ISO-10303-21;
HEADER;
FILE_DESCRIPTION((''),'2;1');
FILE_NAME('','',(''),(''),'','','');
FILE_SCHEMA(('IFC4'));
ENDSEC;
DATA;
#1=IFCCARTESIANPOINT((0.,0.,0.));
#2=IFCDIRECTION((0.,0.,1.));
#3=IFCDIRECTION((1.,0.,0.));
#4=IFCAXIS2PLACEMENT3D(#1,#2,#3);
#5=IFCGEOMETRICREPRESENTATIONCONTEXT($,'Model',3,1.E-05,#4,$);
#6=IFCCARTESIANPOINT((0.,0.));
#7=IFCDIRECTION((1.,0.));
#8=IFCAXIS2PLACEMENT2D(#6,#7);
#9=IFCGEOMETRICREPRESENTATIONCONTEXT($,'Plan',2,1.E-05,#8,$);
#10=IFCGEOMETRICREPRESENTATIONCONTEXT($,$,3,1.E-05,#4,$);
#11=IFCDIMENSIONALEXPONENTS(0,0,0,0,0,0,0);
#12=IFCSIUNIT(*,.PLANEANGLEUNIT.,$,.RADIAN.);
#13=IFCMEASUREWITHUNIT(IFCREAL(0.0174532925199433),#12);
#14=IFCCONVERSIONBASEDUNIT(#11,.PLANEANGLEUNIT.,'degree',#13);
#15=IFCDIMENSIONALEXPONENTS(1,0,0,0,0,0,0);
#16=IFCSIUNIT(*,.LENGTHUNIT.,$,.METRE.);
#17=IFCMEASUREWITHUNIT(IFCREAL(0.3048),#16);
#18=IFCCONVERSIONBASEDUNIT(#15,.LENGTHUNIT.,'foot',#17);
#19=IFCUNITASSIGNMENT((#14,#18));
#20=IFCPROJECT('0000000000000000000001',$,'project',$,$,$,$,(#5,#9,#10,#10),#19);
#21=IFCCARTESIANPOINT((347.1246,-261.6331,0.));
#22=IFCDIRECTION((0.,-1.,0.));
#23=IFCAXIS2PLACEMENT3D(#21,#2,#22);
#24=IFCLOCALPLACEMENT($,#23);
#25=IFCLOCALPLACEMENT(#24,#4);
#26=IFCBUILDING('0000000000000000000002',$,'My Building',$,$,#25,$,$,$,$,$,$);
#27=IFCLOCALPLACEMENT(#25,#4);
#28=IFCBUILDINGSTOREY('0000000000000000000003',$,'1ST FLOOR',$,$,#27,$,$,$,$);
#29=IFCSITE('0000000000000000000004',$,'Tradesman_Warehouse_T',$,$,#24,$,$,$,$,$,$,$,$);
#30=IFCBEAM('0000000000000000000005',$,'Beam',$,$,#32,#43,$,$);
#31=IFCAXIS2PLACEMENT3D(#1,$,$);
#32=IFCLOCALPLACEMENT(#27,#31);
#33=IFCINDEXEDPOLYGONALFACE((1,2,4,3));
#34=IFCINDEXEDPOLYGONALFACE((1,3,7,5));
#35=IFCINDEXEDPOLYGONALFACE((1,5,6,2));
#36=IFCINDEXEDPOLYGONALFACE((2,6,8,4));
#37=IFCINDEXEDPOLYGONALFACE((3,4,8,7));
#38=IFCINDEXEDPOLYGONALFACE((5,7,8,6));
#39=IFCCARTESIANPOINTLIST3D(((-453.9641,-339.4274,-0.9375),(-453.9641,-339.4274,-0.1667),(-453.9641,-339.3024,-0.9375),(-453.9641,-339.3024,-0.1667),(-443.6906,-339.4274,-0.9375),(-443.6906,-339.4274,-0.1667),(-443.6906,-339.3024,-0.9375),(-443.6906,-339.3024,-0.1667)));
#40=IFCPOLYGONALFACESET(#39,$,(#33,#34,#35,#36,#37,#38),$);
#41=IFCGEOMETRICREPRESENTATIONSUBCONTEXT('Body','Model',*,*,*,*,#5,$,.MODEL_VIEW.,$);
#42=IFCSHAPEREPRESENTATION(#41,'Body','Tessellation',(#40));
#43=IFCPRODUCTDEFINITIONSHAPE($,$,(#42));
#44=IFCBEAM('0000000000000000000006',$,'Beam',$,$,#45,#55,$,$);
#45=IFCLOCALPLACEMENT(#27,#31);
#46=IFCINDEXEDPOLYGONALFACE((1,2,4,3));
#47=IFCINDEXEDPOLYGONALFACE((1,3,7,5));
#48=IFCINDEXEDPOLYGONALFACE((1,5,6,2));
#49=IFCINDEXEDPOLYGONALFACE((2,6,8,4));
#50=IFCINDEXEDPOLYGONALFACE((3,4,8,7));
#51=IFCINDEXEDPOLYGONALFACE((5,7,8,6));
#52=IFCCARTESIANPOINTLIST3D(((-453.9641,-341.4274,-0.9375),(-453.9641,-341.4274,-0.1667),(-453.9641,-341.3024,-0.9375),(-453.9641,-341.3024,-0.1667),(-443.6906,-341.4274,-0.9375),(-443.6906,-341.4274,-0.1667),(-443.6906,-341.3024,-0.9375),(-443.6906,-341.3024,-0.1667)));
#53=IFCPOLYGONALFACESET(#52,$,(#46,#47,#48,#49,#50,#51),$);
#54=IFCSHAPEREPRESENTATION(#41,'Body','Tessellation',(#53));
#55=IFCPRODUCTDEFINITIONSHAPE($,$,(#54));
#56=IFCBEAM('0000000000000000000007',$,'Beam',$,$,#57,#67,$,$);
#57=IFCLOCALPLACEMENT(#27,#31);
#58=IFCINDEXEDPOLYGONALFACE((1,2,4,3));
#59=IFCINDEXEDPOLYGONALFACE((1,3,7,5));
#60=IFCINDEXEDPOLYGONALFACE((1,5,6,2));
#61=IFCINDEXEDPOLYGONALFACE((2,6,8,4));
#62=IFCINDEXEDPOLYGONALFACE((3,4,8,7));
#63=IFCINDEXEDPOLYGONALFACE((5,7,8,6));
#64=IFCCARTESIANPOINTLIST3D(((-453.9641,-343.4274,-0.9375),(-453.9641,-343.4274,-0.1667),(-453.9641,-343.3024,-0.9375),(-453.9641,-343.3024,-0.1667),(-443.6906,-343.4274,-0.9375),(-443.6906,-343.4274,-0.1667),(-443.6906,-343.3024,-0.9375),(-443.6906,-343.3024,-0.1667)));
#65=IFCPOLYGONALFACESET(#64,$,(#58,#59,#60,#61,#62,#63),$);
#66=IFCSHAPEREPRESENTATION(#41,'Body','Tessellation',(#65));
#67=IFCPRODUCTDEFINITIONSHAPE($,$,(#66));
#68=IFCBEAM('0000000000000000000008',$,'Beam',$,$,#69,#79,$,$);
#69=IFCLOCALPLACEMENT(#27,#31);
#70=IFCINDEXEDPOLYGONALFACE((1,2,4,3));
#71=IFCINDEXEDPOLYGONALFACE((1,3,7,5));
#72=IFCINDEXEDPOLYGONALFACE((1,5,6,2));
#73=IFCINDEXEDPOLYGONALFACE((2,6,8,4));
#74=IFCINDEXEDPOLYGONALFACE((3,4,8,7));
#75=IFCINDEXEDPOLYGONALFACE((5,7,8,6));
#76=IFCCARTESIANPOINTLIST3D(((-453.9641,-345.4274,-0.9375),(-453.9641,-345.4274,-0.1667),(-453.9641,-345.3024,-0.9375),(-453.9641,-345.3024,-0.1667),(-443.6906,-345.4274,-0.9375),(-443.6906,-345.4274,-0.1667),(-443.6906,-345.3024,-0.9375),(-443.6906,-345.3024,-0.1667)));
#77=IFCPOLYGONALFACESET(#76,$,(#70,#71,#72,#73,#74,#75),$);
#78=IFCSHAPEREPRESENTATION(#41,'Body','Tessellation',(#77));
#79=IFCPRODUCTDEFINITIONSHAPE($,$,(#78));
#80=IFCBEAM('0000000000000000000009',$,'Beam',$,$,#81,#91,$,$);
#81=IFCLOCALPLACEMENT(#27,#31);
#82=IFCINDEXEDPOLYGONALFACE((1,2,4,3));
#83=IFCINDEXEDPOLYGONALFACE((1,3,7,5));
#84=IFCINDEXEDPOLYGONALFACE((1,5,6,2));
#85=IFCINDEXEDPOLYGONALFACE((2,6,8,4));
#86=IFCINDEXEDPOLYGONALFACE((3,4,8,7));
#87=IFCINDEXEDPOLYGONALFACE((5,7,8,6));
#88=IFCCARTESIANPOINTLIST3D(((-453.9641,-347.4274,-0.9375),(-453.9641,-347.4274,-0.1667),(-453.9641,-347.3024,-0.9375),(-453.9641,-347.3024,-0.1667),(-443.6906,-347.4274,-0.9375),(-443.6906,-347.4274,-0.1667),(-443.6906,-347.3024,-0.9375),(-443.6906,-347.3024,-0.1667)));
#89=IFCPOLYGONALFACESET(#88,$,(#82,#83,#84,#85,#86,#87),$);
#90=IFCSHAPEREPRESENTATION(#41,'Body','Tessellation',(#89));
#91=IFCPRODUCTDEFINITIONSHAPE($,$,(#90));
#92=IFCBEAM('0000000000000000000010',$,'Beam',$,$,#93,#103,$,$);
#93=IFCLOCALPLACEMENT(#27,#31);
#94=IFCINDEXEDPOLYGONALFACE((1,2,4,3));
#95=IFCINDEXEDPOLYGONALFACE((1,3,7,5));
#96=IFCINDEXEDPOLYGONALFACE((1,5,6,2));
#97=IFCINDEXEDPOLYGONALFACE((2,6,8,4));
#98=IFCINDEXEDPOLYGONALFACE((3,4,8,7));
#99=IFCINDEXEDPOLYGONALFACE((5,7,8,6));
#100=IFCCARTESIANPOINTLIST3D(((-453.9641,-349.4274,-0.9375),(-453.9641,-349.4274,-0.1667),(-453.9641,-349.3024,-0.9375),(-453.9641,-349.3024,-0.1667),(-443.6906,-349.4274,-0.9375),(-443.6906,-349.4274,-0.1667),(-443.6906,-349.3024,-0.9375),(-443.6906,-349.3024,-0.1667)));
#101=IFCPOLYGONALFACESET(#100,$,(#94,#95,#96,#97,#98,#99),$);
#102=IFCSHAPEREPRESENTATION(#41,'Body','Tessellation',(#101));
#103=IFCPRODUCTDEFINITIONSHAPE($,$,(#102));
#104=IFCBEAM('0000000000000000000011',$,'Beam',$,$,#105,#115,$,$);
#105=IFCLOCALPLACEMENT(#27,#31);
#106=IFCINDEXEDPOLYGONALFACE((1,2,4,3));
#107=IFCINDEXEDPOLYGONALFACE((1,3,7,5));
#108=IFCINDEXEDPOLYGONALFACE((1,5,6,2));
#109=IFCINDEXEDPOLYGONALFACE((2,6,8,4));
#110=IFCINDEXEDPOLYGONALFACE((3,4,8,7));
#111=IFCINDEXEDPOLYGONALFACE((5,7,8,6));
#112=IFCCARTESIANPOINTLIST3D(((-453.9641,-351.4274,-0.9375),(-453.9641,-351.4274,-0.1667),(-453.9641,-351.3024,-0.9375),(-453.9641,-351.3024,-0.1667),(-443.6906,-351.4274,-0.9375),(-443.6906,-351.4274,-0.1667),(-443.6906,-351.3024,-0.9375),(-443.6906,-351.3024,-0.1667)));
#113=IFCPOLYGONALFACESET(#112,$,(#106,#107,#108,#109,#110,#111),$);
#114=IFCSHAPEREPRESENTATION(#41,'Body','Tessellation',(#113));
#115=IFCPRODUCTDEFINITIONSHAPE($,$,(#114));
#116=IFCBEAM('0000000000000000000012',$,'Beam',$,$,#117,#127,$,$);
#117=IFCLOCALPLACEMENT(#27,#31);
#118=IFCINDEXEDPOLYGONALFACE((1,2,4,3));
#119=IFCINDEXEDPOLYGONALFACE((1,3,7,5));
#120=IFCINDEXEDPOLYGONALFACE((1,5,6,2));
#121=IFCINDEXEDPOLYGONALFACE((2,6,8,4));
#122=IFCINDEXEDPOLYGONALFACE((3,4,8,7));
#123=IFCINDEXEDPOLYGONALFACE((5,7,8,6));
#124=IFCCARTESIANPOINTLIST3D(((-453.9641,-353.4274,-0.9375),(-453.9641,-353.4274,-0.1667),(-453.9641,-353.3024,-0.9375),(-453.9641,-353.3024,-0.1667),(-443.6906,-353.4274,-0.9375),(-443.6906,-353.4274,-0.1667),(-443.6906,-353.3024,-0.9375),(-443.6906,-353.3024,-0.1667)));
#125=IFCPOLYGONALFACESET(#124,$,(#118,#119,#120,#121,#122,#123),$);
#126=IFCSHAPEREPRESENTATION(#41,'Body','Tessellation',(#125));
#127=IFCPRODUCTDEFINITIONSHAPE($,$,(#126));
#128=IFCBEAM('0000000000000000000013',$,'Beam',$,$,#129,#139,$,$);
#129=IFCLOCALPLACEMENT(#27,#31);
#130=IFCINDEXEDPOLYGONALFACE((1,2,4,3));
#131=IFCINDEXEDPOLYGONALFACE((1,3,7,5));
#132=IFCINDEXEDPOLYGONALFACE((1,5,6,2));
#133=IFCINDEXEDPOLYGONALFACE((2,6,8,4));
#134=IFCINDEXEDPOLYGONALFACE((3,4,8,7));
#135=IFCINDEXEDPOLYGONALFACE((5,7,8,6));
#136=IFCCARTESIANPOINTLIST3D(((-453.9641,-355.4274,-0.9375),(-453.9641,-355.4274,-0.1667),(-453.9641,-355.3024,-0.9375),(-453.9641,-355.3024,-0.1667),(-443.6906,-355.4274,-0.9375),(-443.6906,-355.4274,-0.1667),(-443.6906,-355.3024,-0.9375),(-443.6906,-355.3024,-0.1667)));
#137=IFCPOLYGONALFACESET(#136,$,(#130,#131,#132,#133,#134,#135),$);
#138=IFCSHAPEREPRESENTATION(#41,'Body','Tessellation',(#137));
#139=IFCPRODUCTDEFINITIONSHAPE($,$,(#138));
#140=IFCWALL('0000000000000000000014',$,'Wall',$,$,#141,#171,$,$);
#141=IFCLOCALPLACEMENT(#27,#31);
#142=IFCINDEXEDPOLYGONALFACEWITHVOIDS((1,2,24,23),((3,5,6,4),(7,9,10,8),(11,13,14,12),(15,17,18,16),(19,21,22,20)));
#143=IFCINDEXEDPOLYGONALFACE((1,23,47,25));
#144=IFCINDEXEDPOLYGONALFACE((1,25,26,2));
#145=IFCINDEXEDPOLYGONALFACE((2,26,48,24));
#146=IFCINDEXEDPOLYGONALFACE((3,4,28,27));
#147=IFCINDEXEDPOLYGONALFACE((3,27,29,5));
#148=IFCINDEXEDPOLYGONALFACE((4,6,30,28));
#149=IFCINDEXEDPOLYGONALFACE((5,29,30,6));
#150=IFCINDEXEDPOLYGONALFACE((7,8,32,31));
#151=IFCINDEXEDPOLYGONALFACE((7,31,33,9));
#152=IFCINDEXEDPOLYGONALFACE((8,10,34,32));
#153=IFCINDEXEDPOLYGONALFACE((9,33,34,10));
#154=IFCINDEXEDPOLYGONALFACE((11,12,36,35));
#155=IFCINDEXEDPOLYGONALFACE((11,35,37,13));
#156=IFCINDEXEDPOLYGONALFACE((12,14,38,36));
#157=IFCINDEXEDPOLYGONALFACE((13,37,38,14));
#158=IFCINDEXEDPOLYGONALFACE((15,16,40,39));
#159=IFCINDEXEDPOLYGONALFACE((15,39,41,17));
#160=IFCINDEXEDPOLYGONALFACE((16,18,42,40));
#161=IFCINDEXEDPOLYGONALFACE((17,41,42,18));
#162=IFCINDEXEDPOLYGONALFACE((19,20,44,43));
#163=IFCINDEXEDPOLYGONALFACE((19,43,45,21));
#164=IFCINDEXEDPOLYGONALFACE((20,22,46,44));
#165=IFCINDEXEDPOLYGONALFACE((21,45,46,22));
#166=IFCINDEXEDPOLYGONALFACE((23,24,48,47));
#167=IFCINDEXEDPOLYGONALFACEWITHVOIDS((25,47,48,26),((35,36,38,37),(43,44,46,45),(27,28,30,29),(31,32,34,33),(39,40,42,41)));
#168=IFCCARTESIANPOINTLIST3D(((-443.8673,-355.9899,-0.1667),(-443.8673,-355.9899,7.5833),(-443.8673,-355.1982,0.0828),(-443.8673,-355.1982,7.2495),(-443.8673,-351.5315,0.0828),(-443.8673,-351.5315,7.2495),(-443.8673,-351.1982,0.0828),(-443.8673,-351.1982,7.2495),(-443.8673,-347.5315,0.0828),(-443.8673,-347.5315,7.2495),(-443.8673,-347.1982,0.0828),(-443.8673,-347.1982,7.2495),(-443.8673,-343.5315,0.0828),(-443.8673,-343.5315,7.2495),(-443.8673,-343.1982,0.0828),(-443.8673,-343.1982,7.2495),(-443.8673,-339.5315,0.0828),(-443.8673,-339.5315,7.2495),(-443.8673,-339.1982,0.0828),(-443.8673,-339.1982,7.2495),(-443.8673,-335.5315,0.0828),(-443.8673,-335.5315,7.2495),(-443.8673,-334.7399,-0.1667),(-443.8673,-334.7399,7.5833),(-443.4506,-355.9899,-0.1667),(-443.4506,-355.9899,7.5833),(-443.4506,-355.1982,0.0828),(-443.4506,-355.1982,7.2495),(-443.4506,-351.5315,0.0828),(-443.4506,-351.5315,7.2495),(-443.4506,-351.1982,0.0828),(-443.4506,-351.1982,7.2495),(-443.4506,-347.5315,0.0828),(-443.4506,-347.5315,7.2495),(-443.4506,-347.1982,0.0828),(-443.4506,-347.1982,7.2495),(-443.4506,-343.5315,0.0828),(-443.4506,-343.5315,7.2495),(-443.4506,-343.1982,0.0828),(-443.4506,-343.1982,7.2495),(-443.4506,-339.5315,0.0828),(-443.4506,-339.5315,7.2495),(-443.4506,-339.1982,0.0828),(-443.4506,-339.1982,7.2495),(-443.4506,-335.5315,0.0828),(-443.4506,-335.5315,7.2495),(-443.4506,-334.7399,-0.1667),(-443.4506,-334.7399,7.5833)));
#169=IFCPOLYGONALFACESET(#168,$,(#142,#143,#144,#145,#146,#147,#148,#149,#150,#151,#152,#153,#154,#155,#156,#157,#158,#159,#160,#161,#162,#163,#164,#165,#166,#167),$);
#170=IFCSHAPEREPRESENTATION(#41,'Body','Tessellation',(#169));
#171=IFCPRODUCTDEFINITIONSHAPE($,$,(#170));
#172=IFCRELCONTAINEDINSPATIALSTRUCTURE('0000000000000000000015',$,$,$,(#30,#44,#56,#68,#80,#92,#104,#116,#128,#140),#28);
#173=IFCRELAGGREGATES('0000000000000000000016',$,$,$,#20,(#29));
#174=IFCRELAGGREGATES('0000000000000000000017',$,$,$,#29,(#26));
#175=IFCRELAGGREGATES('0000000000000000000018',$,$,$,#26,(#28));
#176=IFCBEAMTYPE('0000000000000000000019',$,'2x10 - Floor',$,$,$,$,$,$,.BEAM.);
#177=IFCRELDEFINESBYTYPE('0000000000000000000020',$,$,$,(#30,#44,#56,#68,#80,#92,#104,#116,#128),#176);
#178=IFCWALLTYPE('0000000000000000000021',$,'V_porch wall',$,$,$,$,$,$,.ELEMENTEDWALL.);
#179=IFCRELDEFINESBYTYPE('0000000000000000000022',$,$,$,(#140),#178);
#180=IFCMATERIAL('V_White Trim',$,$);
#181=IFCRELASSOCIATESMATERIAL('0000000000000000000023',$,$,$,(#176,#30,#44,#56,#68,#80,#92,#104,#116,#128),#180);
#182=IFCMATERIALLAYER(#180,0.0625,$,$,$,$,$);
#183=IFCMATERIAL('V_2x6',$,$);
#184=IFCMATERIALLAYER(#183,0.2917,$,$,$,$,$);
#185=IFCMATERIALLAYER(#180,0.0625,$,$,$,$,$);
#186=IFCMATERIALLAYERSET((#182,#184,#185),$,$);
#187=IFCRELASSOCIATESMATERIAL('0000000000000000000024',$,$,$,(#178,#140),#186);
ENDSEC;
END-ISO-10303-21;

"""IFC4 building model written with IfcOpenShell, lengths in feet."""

from ifc_helpers import new_model, entity, si_unit, converted_unit, frame, origin_with_axes, origin_2d_with_axis, place, context, subcontext, project, spatial, line, indexed_curve, rectangle, outline, extrude, source, transform, mapped, material, layer, layer_set, layer_usage, material_profile, profile_set, profile_usage, type_object, element, save


model = new_model("IFC4")

# Units and contexts
model_context = context("Model", 3, precision=1e-05, world=origin_with_axes())
plan_context = context("Plan", 2, precision=1e-05, world=origin_2d_with_axis())
context_of_model = context(None, 3, precision=1e-05, world=origin_with_axes())
body_context = subcontext(model_context, "Body", "Model", "MODEL_VIEW")
ifc_project = project(units=[converted_unit("PLANEANGLEUNIT", "degree", entity("IfcReal", 0.0174532925199433), si_unit("PLANEANGLEUNIT", "RADIAN"), dimensions=[0, 0, 0, 0, 0, 0, 0]), converted_unit("LENGTHUNIT", "foot", entity("IfcReal", 0.3048), si_unit("LENGTHUNIT", "METRE"), dimensions=[1, 0, 0, 0, 0, 0, 0])], contexts=[model_context, plan_context, context_of_model, context_of_model])

# Site, building, storey
site_placement = place(None, frame((347.1246, -261.6331, 0.0), z_axis=(0.0, 0.0, 1.0), x_axis=(0.0, -1.0, 0.0)))
site = spatial("IfcSite", under=ifc_project, at=site_placement, Name="Tradesman_Warehouse_T")
building_placement = place(site_placement, frame((0.0, 0.0, 0.0), z_axis=(0.0, 0.0, 1.0), x_axis=(1.0, 0.0, 0.0)))
building = spatial("IfcBuilding", under=site, at=building_placement, Name="My Building")
storey_placement = place(building_placement, frame((0.0, 0.0, 0.0), z_axis=(0.0, 0.0, 1.0), x_axis=(1.0, 0.0, 0.0)))
storey = spatial("IfcBuildingStorey", under=building, at=storey_placement, Name="1ST FLOOR")

# Beams
ifc_material_1 = material(Name="V_White Trim")
ifc_material_profile_1 = material_profile(ifc_material_1, rectangle(XDim=0.125, YDim=0.7708))
ifc_profile_set_1 = profile_set([ifc_material_profile_1])
ifc_profile_usage_1 = profile_usage(ifc_profile_set_1, cardinal=5)
beam_type_1 = type_object("IfcBeamType", Name="2x10 - Floor", PredefinedType="BEAM", material=ifc_profile_set_1)
beam_1_placement = place(storey_placement, frame((-453.9641, -339.3649, -0.5521), z_axis=(1.0, 0.0, 0.0), x_axis=(0.0, 1.0, 0.0)))
element("IfcBeam", 1, at=beam_1_placement, inside=storey, type_object=beam_type_1, material=ifc_profile_usage_1, Name="Beam", context=body_context, shape_type="SweptSolid", body=[
    extrude(rectangle(XDim=0.125, YDim=0.7708), origin_with_axes(), (0.0, 0.0, 1.0), 10.2735),
])
ifc_profile_usage_2 = profile_usage(ifc_profile_set_1, cardinal=5)
beam_2_placement = place(storey_placement, frame((-453.9641, -341.3649, -0.5521), z_axis=(1.0, 0.0, 0.0), x_axis=(0.0, 1.0, 0.0)))
element("IfcBeam", 2, at=beam_2_placement, inside=storey, type_object=beam_type_1, material=ifc_profile_usage_2, Name="Beam", context=body_context, shape_type="SweptSolid", body=[
    extrude(rectangle(XDim=0.125, YDim=0.7708), origin_with_axes(), (0.0, 0.0, 1.0), 10.2735),
])
ifc_profile_usage_3 = profile_usage(ifc_profile_set_1, cardinal=5)
beam_3_placement = place(storey_placement, frame((-453.9641, -343.3649, -0.5521), z_axis=(1.0, 0.0, 0.0), x_axis=(0.0, 1.0, 0.0)))
element("IfcBeam", 3, at=beam_3_placement, inside=storey, type_object=beam_type_1, material=ifc_profile_usage_3, Name="Beam", context=body_context, shape_type="SweptSolid", body=[
    extrude(rectangle(XDim=0.125, YDim=0.7708), origin_with_axes(), (0.0, 0.0, 1.0), 10.2735),
])
ifc_profile_usage_4 = profile_usage(ifc_profile_set_1, cardinal=5)
beam_4_placement = place(storey_placement, frame((-453.9641, -345.3649, -0.5521), z_axis=(1.0, 0.0, 0.0), x_axis=(0.0, 1.0, 0.0)))
element("IfcBeam", 4, at=beam_4_placement, inside=storey, type_object=beam_type_1, material=ifc_profile_usage_4, Name="Beam", context=body_context, shape_type="SweptSolid", body=[
    extrude(rectangle(XDim=0.125, YDim=0.7708), origin_with_axes(), (0.0, 0.0, 1.0), 10.2735),
])
ifc_profile_usage_5 = profile_usage(ifc_profile_set_1, cardinal=5)
beam_5_placement = place(storey_placement, frame((-453.9641, -347.3649, -0.5521), z_axis=(1.0, 0.0, 0.0), x_axis=(0.0, 1.0, 0.0)))
element("IfcBeam", 5, at=beam_5_placement, inside=storey, type_object=beam_type_1, material=ifc_profile_usage_5, Name="Beam", context=body_context, shape_type="SweptSolid", body=[
    extrude(rectangle(XDim=0.125, YDim=0.7708), origin_with_axes(), (0.0, 0.0, 1.0), 10.2735),
])
ifc_profile_usage_6 = profile_usage(ifc_profile_set_1, cardinal=5)
beam_6_placement = place(storey_placement, frame((-453.9641, -349.3649, -0.5521), z_axis=(1.0, 0.0, 0.0), x_axis=(0.0, 1.0, 0.0)))
element("IfcBeam", 6, at=beam_6_placement, inside=storey, type_object=beam_type_1, material=ifc_profile_usage_6, Name="Beam", context=body_context, shape_type="SweptSolid", body=[
    extrude(rectangle(XDim=0.125, YDim=0.7708), origin_with_axes(), (0.0, 0.0, 1.0), 10.2735),
])
ifc_profile_usage_7 = profile_usage(ifc_profile_set_1, cardinal=5)
beam_7_placement = place(storey_placement, frame((-453.9641, -351.3649, -0.5521), z_axis=(1.0, 0.0, 0.0), x_axis=(0.0, 1.0, 0.0)))
element("IfcBeam", 7, at=beam_7_placement, inside=storey, type_object=beam_type_1, material=ifc_profile_usage_7, Name="Beam", context=body_context, shape_type="SweptSolid", body=[
    extrude(rectangle(XDim=0.125, YDim=0.7708), origin_with_axes(), (0.0, 0.0, 1.0), 10.2735),
])
ifc_profile_usage_8 = profile_usage(ifc_profile_set_1, cardinal=5)
beam_8_placement = place(storey_placement, frame((-453.9641, -353.3649, -0.5521), z_axis=(1.0, 0.0, 0.0), x_axis=(0.0, 1.0, 0.0)))
element("IfcBeam", 8, at=beam_8_placement, inside=storey, type_object=beam_type_1, material=ifc_profile_usage_8, Name="Beam", context=body_context, shape_type="SweptSolid", body=[
    extrude(rectangle(XDim=0.125, YDim=0.7708), origin_with_axes(), (0.0, 0.0, 1.0), 10.2735),
])
ifc_profile_usage_9 = profile_usage(ifc_profile_set_1, cardinal=5)
beam_9_placement = place(storey_placement, frame((-453.9641, -355.3649, -0.5521), z_axis=(1.0, 0.0, 0.0), x_axis=(0.0, 1.0, 0.0)))
element("IfcBeam", 9, at=beam_9_placement, inside=storey, type_object=beam_type_1, material=ifc_profile_usage_9, Name="Beam", context=body_context, shape_type="SweptSolid", body=[
    extrude(rectangle(XDim=0.125, YDim=0.7708), origin_with_axes(), (0.0, 0.0, 1.0), 10.2735),
])

# Wall, openings
ifc_layer_1 = layer(ifc_material_1, 0.0625)
ifc_material_2 = material(Name="V_2x6")
ifc_layer_2 = layer(ifc_material_2, 0.2917)
ifc_layer_3 = layer(ifc_material_1, 0.0625)
ifc_layer_set_1 = layer_set([ifc_layer_1, ifc_layer_2, ifc_layer_3])
ifc_layer_usage_1 = layer_usage(ifc_layer_set_1, "AXIS2", "POSITIVE", 0.0)
wall_type_1 = type_object("IfcWallType", Name="V_porch wall", PredefinedType="ELEMENTEDWALL", material=ifc_layer_set_1)
wall_1_placement = place(storey_placement, frame((-443.4506, -355.9899, -0.1667), z_axis=(0.0, 0.0, 1.0), x_axis=(0.0, 1.0, 0.0)))
wall_1 = element("IfcWall", 10, at=wall_1_placement, inside=storey, type_object=wall_type_1, material=ifc_layer_usage_1, Name="Wall", context=body_context, shape_type="SweptSolid", body=[
    extrude(outline(indexed_curve([(0.0, 0.0), (0.0, 0.4167), (21.25, 0.4167), (21.25, 0.0), (0.0, 0.0)], self_intersect=False)), origin_with_axes(), (0.0, 0.0, 1.0), 7.75),
])
shared_shape = source(origin_with_axes(), body_context, "Body", "SweptSolid", [
    extrude(outline(indexed_curve([(0.0, 0.0), (3.6667, 0.0), (3.6667, 7.1667), (0.0, 7.1667)], segments=[line(1, 2, 3, 4, 1)])), frame((0.0, -1.9685, 0.0), z_axis=(0.0, -1.0, 0.0), x_axis=(1.0, 0.0, 0.0)), (0.0, 0.0, -1.0), 3.937),
])
opening_1_placement = place(wall_1_placement, frame((16.7917, 0.0, 0.2495), z_axis=(0.0, 0.0, 1.0), x_axis=(1.0, 0.0, 0.0)))
element("IfcOpeningElement", 11, at=opening_1_placement, cuts=wall_1, PredefinedType="OPENING", context=body_context, shape_type="MappedRepresentation", body=[
    mapped(shared_shape, transform((0.0, 0.0, 0.0), x_axis=(1.0, 0.0, 0.0), y_axis=(0.0, 1.0, 0.0), z_axis=(0.0, 0.0, 1.0), scale=1.0)),
])
opening_2_placement = place(wall_1_placement, frame((12.7917, 0.0, 0.2495), z_axis=(0.0, 0.0, 1.0), x_axis=(1.0, 0.0, 0.0)))
element("IfcOpeningElement", 12, at=opening_2_placement, cuts=wall_1, PredefinedType="OPENING", context=body_context, shape_type="MappedRepresentation", body=[
    mapped(shared_shape, transform((0.0, 0.0, 0.0), x_axis=(1.0, 0.0, 0.0), y_axis=(0.0, 1.0, 0.0), z_axis=(0.0, 0.0, 1.0), scale=1.0)),
])
opening_3_placement = place(wall_1_placement, frame((8.7917, 0.0, 0.2495), z_axis=(0.0, 0.0, 1.0), x_axis=(1.0, 0.0, 0.0)))
element("IfcOpeningElement", 13, at=opening_3_placement, cuts=wall_1, PredefinedType="OPENING", context=body_context, shape_type="MappedRepresentation", body=[
    mapped(shared_shape, transform((0.0, 0.0, 0.0), x_axis=(1.0, 0.0, 0.0), y_axis=(0.0, 1.0, 0.0), z_axis=(0.0, 0.0, 1.0), scale=1.0)),
])
opening_4_placement = place(wall_1_placement, frame((4.7917, 0.0, 0.2495), z_axis=(0.0, 0.0, 1.0), x_axis=(1.0, 0.0, 0.0)))
element("IfcOpeningElement", 14, at=opening_4_placement, cuts=wall_1, PredefinedType="OPENING", context=body_context, shape_type="MappedRepresentation", body=[
    mapped(shared_shape, transform((0.0, 0.0, 0.0), x_axis=(1.0, 0.0, 0.0), y_axis=(0.0, 1.0, 0.0), z_axis=(0.0, 0.0, 1.0), scale=1.0)),
])
opening_5_placement = place(wall_1_placement, frame((0.7917, 0.0, 0.2495), z_axis=(0.0, 0.0, 1.0), x_axis=(1.0, 0.0, 0.0)))
element("IfcOpeningElement", 15, at=opening_5_placement, cuts=wall_1, PredefinedType="OPENING", context=body_context, shape_type="MappedRepresentation", body=[
    mapped(shared_shape, transform((0.0, 0.0, 0.0), x_axis=(1.0, 0.0, 0.0), y_axis=(0.0, 1.0, 0.0), z_axis=(0.0, 0.0, 1.0), scale=1.0)),
])

save(model, "model.ifc")
